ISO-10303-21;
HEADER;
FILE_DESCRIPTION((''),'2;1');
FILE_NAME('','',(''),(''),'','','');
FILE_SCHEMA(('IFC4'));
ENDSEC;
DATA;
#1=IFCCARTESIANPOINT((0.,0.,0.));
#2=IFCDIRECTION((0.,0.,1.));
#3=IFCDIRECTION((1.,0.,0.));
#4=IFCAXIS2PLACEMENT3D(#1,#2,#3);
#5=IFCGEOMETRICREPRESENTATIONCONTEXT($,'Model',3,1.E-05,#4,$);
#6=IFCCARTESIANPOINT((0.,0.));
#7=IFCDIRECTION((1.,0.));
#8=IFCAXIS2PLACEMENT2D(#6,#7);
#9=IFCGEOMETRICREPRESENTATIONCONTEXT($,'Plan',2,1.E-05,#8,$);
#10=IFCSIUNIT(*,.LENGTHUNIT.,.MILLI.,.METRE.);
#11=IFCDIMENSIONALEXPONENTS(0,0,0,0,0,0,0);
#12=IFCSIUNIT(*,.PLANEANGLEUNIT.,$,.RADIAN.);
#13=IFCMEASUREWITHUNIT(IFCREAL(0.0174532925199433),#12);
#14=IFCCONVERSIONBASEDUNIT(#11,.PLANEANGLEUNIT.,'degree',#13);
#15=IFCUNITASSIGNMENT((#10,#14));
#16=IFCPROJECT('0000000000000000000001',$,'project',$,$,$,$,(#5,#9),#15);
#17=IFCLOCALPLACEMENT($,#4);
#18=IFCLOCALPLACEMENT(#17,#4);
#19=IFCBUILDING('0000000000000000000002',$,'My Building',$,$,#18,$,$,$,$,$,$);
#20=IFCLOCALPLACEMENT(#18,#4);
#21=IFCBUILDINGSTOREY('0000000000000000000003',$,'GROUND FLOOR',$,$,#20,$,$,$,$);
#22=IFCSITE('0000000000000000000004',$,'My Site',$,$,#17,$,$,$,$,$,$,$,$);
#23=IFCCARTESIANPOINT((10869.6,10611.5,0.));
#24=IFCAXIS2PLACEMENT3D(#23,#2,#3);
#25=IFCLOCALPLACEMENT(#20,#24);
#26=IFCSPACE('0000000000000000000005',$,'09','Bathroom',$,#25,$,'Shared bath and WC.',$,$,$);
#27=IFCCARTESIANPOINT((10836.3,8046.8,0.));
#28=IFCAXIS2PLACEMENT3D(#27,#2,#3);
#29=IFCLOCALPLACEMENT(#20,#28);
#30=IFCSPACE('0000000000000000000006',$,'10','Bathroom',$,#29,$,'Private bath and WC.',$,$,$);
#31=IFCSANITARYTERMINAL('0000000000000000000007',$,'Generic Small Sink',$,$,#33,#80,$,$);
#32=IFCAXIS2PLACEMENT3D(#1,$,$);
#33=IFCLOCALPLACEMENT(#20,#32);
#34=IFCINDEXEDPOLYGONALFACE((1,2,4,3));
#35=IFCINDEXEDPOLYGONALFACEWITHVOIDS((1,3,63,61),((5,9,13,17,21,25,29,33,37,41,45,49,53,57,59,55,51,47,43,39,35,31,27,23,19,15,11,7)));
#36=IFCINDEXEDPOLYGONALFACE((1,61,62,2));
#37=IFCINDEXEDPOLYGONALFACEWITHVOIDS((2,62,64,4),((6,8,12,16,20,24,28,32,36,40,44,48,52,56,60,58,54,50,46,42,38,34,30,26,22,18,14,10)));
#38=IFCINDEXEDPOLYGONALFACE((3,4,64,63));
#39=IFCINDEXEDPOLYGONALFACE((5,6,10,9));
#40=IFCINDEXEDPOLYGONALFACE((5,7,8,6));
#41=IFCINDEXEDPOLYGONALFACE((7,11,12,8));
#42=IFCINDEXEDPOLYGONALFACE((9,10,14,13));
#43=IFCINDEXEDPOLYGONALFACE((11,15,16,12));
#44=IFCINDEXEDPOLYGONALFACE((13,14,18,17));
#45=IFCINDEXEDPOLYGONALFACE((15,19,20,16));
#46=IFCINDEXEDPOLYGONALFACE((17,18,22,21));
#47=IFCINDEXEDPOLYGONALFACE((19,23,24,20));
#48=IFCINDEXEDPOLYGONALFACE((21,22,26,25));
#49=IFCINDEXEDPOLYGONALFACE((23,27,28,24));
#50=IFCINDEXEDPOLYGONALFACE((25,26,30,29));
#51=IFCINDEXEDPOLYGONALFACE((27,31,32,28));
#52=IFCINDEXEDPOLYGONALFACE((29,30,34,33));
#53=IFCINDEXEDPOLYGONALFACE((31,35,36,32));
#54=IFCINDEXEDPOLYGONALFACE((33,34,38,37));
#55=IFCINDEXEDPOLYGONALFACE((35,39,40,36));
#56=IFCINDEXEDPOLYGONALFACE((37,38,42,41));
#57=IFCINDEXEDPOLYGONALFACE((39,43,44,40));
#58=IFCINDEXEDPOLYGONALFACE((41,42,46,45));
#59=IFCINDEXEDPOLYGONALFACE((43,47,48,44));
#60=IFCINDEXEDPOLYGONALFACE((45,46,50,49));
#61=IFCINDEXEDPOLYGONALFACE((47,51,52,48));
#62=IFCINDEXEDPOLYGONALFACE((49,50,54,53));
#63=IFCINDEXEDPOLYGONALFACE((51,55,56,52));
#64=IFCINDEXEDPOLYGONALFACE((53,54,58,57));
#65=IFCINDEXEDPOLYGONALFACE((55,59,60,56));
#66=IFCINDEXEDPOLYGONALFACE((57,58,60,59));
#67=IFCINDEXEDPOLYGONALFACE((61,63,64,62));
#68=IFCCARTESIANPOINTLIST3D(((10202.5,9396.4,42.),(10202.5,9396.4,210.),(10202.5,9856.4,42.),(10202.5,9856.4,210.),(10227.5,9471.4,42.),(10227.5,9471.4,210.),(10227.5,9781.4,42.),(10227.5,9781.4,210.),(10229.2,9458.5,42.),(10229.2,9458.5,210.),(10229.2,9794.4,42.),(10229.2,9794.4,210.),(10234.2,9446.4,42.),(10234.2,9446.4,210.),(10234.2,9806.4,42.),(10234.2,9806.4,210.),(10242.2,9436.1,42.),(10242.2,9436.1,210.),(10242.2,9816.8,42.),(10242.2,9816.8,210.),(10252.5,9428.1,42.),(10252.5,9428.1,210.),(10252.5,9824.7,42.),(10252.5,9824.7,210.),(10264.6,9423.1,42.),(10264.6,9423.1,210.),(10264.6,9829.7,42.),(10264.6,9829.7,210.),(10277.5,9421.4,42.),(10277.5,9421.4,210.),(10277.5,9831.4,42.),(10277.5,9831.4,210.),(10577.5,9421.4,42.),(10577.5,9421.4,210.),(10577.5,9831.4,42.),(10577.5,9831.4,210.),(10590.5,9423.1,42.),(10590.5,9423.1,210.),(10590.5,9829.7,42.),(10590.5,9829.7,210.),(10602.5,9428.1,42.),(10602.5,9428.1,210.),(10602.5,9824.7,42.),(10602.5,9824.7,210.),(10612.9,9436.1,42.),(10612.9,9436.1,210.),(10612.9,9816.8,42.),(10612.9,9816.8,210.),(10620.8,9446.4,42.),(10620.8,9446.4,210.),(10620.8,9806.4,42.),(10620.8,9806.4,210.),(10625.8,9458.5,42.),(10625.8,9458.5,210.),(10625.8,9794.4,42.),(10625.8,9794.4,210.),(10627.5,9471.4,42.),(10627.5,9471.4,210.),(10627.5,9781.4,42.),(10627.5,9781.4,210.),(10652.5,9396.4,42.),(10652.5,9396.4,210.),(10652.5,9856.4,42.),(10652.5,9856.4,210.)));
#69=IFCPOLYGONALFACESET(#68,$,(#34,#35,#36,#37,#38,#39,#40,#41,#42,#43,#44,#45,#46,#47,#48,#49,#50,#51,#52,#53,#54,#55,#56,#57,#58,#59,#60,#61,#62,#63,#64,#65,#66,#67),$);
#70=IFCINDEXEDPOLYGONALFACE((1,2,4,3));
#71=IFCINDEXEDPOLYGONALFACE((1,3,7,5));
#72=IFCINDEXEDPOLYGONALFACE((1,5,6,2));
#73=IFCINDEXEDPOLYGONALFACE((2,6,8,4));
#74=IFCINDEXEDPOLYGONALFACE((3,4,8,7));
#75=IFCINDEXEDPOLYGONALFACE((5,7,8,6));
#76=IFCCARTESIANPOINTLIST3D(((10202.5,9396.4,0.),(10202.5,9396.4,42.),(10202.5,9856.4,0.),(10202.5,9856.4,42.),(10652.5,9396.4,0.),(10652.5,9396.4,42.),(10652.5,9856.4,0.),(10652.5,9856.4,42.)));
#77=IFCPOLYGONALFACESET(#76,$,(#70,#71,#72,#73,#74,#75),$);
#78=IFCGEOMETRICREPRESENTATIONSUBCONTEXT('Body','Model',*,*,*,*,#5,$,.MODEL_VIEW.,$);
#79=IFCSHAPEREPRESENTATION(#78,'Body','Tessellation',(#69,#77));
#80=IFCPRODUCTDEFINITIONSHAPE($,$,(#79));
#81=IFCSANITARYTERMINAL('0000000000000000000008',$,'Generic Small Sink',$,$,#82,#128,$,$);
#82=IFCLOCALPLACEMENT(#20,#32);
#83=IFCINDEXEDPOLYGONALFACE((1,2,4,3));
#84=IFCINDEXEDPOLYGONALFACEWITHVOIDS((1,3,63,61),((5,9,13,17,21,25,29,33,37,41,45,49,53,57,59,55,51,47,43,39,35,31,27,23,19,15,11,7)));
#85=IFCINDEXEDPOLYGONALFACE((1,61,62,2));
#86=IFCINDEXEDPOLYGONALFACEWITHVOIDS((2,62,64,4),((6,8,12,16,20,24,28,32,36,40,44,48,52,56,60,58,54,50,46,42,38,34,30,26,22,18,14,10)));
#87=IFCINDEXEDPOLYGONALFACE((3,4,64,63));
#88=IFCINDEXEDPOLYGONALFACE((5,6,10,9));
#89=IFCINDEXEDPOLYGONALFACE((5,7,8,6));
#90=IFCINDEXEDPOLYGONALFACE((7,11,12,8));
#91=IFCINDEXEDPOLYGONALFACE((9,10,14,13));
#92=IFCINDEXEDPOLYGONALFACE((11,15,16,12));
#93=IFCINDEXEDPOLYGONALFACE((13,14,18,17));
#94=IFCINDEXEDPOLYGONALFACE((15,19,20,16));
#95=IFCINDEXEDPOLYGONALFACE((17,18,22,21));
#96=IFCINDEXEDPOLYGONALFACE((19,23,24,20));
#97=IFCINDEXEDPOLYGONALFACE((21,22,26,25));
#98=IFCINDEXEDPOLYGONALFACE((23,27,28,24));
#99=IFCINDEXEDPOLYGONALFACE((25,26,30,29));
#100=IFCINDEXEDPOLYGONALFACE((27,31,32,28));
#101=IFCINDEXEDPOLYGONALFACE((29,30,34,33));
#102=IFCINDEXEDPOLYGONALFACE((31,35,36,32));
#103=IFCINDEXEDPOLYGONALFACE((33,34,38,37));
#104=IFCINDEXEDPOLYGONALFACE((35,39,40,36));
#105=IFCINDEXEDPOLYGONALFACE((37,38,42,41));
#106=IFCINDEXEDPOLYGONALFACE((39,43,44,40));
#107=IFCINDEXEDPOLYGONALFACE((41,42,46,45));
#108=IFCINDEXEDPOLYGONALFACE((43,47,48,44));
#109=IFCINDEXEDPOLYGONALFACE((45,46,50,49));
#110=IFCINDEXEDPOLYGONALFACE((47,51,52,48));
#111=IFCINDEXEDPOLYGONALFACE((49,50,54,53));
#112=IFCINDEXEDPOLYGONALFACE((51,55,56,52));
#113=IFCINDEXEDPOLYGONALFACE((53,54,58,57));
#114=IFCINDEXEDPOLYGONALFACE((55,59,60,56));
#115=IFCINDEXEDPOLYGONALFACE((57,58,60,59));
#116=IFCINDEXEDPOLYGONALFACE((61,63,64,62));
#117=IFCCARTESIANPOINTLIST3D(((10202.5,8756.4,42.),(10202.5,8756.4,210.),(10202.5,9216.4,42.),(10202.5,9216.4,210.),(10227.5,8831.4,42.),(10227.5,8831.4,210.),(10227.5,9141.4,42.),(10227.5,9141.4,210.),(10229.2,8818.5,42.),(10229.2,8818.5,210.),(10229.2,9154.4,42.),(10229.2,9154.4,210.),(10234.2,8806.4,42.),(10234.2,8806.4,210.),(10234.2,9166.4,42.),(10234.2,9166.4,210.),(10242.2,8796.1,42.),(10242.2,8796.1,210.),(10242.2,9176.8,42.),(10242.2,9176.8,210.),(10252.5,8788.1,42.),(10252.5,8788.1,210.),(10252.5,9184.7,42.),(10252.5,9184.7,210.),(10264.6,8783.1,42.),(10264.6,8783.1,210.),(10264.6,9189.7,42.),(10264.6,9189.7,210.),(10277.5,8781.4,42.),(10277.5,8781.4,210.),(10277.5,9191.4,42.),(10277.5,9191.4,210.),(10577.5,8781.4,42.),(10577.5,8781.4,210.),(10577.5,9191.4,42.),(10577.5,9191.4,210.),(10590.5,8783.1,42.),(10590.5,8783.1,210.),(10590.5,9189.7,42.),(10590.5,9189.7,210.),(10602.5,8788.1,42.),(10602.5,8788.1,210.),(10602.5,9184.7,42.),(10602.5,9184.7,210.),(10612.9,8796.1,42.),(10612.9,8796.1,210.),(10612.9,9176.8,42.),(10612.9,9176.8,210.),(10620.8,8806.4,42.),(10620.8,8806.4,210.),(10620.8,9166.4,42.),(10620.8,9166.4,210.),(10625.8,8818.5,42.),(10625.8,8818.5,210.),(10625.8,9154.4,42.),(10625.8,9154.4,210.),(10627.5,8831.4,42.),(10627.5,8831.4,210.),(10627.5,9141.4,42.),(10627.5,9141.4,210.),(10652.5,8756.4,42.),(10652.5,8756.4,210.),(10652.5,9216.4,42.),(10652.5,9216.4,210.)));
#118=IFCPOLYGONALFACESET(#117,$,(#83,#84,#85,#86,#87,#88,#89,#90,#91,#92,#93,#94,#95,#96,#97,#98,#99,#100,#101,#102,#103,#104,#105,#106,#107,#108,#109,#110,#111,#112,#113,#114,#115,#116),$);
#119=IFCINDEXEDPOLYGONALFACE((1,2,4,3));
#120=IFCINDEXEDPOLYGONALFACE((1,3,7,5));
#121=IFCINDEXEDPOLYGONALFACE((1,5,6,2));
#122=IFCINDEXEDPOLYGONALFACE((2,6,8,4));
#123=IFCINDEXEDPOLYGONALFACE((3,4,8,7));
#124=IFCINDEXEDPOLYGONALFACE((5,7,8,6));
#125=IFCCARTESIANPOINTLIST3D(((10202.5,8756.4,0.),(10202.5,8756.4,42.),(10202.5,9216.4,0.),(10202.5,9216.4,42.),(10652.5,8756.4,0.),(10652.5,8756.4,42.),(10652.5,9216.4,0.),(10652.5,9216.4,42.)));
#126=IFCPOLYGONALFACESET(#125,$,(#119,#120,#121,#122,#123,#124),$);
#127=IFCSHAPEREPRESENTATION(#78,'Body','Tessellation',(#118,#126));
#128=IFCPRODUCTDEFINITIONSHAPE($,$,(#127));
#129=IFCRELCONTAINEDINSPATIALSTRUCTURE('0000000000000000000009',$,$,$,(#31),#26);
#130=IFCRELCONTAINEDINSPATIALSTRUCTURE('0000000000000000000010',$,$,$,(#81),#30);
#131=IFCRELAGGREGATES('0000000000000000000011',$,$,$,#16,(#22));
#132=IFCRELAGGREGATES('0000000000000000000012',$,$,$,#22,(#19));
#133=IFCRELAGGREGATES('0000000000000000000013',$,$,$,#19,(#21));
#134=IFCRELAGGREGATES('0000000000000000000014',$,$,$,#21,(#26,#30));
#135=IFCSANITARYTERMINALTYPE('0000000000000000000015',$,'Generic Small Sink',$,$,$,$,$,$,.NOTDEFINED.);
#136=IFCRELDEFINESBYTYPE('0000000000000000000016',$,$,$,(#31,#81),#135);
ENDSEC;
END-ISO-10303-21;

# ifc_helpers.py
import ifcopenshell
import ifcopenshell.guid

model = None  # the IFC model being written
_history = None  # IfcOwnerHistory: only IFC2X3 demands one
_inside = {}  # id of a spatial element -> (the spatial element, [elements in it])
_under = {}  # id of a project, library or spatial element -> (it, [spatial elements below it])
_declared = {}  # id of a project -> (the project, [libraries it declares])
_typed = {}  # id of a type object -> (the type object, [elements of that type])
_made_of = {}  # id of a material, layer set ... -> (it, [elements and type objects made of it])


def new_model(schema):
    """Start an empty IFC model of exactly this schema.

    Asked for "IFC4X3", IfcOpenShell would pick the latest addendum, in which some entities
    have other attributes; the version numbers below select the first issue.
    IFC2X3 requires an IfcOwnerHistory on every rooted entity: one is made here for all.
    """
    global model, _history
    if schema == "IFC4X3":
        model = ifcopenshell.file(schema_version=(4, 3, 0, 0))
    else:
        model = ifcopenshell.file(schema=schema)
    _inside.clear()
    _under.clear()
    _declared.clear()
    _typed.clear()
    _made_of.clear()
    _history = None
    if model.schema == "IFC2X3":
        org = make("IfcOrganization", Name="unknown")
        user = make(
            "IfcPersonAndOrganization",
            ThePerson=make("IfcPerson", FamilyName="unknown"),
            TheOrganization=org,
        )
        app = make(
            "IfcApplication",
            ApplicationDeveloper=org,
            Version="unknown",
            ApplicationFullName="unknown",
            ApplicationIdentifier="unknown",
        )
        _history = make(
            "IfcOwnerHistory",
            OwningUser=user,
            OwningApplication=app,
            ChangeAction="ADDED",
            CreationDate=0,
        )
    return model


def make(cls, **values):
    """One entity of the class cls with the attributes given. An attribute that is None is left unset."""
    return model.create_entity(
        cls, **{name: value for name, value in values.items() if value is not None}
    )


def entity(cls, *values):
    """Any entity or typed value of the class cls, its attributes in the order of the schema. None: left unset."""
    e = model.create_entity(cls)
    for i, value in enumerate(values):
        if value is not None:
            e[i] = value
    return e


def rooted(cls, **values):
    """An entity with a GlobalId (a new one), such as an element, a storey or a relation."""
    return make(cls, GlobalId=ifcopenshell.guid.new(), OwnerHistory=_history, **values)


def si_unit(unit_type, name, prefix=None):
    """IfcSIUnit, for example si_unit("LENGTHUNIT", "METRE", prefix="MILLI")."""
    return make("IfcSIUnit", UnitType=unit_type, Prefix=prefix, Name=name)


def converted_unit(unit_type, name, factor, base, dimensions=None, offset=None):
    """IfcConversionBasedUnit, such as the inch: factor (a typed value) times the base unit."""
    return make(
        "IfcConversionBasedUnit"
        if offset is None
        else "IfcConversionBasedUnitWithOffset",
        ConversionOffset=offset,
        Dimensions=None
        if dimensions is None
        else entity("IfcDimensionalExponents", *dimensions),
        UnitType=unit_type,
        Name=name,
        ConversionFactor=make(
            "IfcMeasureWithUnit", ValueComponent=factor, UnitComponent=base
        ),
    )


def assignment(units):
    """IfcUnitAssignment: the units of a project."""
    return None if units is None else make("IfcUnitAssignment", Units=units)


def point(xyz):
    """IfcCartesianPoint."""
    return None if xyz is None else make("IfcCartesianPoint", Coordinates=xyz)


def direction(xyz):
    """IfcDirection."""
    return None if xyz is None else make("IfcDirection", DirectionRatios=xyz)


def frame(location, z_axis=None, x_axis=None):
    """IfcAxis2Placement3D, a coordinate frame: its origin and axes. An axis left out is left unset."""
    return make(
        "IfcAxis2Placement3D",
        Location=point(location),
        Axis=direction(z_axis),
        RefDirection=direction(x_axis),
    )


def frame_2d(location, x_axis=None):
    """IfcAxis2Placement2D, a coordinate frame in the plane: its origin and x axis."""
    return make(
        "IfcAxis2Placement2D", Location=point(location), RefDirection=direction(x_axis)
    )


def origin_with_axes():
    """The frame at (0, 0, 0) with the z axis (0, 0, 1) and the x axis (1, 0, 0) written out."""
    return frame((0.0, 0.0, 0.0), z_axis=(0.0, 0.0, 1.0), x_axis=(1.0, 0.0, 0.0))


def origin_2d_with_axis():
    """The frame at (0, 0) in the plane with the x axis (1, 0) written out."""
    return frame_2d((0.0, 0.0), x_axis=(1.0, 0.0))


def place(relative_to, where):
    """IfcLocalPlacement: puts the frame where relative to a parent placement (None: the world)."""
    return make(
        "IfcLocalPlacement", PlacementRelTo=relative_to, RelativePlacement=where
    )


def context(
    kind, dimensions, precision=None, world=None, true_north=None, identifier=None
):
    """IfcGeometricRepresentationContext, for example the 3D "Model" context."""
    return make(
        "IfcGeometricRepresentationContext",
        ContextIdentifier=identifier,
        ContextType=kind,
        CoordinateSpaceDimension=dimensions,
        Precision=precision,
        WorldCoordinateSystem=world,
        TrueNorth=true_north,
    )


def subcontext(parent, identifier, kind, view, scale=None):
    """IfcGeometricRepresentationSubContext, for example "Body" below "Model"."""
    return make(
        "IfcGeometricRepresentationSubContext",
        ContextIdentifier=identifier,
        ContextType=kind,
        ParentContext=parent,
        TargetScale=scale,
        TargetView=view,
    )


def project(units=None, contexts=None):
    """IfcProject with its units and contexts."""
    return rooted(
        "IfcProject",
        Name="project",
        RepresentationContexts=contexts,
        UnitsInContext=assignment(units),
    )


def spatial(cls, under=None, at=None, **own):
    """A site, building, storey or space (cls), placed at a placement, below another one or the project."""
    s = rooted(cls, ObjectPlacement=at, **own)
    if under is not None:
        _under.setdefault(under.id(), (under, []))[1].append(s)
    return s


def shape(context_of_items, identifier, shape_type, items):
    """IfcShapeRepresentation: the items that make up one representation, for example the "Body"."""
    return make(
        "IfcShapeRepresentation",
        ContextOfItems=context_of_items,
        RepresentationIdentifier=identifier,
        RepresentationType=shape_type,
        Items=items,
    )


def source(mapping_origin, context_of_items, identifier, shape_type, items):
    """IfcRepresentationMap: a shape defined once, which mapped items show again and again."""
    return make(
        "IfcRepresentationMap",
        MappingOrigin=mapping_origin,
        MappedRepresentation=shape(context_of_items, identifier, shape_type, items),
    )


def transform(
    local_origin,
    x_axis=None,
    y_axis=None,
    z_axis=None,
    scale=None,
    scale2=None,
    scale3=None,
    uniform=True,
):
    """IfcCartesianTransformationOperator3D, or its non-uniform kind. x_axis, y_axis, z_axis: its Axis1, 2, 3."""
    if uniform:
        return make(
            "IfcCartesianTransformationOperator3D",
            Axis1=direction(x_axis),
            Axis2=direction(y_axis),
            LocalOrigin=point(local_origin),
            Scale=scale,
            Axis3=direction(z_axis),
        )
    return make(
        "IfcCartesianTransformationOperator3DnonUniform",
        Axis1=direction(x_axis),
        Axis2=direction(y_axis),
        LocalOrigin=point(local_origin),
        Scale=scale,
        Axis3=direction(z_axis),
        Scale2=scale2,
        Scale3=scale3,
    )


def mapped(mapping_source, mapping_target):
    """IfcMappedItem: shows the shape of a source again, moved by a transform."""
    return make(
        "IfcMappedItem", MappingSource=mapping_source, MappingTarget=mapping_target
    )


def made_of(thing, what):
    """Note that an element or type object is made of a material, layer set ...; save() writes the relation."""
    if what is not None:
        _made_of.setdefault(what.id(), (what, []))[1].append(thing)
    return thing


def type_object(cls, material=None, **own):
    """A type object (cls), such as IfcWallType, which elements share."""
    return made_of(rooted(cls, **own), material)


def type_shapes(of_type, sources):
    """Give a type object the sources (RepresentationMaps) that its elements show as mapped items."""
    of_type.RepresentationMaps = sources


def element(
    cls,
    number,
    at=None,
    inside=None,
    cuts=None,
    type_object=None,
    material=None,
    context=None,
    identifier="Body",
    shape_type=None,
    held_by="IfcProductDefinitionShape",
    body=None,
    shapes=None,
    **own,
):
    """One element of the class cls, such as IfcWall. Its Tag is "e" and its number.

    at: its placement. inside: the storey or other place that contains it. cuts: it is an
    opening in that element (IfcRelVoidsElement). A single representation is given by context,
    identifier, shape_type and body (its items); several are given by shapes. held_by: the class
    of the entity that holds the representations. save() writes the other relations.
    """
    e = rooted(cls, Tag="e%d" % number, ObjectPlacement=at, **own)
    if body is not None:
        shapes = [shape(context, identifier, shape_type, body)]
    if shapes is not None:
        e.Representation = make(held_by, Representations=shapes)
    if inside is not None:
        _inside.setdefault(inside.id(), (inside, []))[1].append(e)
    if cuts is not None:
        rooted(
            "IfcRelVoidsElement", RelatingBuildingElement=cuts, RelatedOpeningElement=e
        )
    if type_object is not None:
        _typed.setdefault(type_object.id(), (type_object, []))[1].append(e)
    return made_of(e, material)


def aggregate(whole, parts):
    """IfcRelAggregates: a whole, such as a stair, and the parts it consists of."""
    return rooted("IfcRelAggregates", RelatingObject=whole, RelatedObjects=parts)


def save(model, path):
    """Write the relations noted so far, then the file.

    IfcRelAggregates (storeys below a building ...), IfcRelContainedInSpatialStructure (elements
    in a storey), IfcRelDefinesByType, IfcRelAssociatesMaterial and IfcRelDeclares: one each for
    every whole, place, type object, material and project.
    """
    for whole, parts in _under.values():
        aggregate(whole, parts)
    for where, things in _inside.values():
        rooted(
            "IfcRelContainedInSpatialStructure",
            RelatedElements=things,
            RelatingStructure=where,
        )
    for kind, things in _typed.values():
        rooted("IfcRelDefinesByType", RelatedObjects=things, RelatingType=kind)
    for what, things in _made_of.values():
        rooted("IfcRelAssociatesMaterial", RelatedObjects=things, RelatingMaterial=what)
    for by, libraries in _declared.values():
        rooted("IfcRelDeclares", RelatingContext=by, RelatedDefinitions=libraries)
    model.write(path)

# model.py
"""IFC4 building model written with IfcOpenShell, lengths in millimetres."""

from ifc_helpers import new_model, entity, si_unit, converted_unit, frame, origin_with_axes, origin_2d_with_axis, place, context, subcontext, project, spatial, shape, source, transform, mapped, type_object, type_shapes, element, save


model = new_model("IFC4")

# Units and contexts
model_context = context("Model", 3, precision=1e-05, world=origin_with_axes())
plan_context = context("Plan", 2, precision=1e-05, world=origin_2d_with_axis())
body_context_1 = subcontext(model_context, "Body", "Model", "MODEL_VIEW")
body_context_2 = subcontext(plan_context, "Body", "Plan", "PLAN_VIEW")
ifc_project = project(units=[si_unit("LENGTHUNIT", "METRE", prefix="MILLI"), converted_unit("PLANEANGLEUNIT", "degree", entity("IfcReal", 0.0174532925199433), si_unit("PLANEANGLEUNIT", "RADIAN"), dimensions=[0, 0, 0, 0, 0, 0, 0])], contexts=[model_context, plan_context])

# Site, building, storey
site_placement = place(None, origin_with_axes())
site = spatial("IfcSite", under=ifc_project, at=site_placement, Name="My Site")
building_placement = place(site_placement, origin_with_axes())
building = spatial("IfcBuilding", under=site, at=building_placement, Name="My Building")
storey_placement = place(building_placement, origin_with_axes())
storey = spatial("IfcBuildingStorey", under=building, at=storey_placement, Name="GROUND FLOOR")

# Shared definitions
space_1_placement = place(storey_placement, frame((10869.6, 10611.5, 0.0), z_axis=(0.0, 0.0, 1.0), x_axis=(1.0, 0.0, 0.0)))
space_1 = spatial("IfcSpace", under=storey, at=space_1_placement, Name="09", Description="Bathroom", LongName="Shared bath and WC.")

# Shared definitions
space_2_placement = place(storey_placement, frame((10836.3, 8046.8, 0.0), z_axis=(0.0, 0.0, 1.0), x_axis=(1.0, 0.0, 0.0)))
space_2 = spatial("IfcSpace", under=storey, at=space_2_placement, Name="10", Description="Bathroom", LongName="Private bath and WC.")

# Sanitary terminals
sanitary_terminal_type_1 = type_object("IfcSanitaryTerminalType", Name="Generic Small Sink", PredefinedType="NOTDEFINED")
shared_indexed_poly_curve = entity("IfcIndexedPolyCurve", entity("IfcCartesianPointList2D", [[0.0, 0.0], [450.0, 0.0], [450.0, 460.0], [0.0, 460.0]]), [entity("IfcLineIndex", [1, 2, 3, 4, 1])])
shared_shape_1 = source(origin_with_axes(), body_context_1, "Body", "SweptSolid", [
    entity("IfcExtrudedAreaSolid", entity("IfcArbitraryProfileDefWithVoids", "AREA", None, shared_indexed_poly_curve, [entity("IfcIndexedPolyCurve", entity("IfcCartesianPointList2D", [[25.0, 75.0], [39.6, 39.6], [75.0, 25.0], [375.0, 25.0], [410.4, 39.6], [425.0, 75.0], [425.0, 385.0], [410.4, 420.4], [375.0, 435.0], [75.0, 435.0], [39.6, 420.4], [25.0, 385.0]]), [entity("IfcLineIndex", [12, 1]), entity("IfcArcIndex", [1, 2, 3]), entity("IfcLineIndex", [3, 4]), entity("IfcArcIndex", [4, 5, 6]), entity("IfcLineIndex", [6, 7]), entity("IfcArcIndex", [7, 8, 9]), entity("IfcLineIndex", [9, 10]), entity("IfcArcIndex", [10, 11, 12]), entity("IfcLineIndex", [12, 1])])]), entity("IfcAxis2Placement3D", entity("IfcCartesianPoint", [-225.0, -460.0, 42.0]), entity("IfcDirection", [0.0, 0.0, 1.0]), entity("IfcDirection", [1.0, 0.0, 0.0])), entity("IfcDirection", [0.0, 0.0, 1.0]), 168.0),
    entity("IfcExtrudedAreaSolid", entity("IfcArbitraryClosedProfileDef", "AREA", None, shared_indexed_poly_curve), entity("IfcAxis2Placement3D", entity("IfcCartesianPoint", [-225.0, -460.0, 0.0]), entity("IfcDirection", [0.0, 0.0, 1.0]), entity("IfcDirection", [1.0, 0.0, 0.0])), entity("IfcDirection", [0.0, 0.0, 1.0]), 42.0),
])
shared_shape_2 = source(origin_with_axes(), body_context_2, "Body", "Curve2D", [
    entity("IfcIndexedPolyCurve", entity("IfcCartesianPointList2D", [[-225.0, -460.0], [225.0, -460.0], [225.0, 0.0], [-225.0, 0.0]]), [entity("IfcLineIndex", [1, 2, 3, 4, 1])]),
    entity("IfcIndexedPolyCurve", entity("IfcCartesianPointList2D", [[-200.0, -385.0], [-185.4, -420.4], [-150.0, -435.0], [150.0, -435.0], [185.4, -420.4], [200.0, -385.0], [200.0, -75.0], [185.4, -39.6], [150.0, -25.0], [-150.0, -25.0], [-185.4, -39.6], [-200.0, -75.0]]), [entity("IfcLineIndex", [12, 1]), entity("IfcArcIndex", [1, 2, 3]), entity("IfcLineIndex", [3, 4]), entity("IfcArcIndex", [4, 5, 6]), entity("IfcLineIndex", [6, 7]), entity("IfcArcIndex", [7, 8, 9]), entity("IfcLineIndex", [9, 10]), entity("IfcArcIndex", [10, 11, 12]), entity("IfcLineIndex", [12, 1])]),
    entity("IfcCircle", entity("IfcAxis2Placement2D", entity("IfcCartesianPoint", [0.0, -125.0])), 25.0),
    entity("IfcIndexedPolyCurve", entity("IfcCartesianPointList2D", [[0.0, -12.5], [0.0, -132.5]])),
])
type_shapes(sanitary_terminal_type_1, [shared_shape_1, shared_shape_2])
sanitary_terminal_1_placement = place(space_1_placement, frame((-442.1, -1215.1, 0.0), z_axis=(0.0, 0.0, 1.0), x_axis=(-1.0, 0.0, 0.0)))
element("IfcSanitaryTerminal", 1, at=sanitary_terminal_1_placement, inside=space_1, type_object=sanitary_terminal_type_1, Name="Generic Small Sink", shapes=[
    shape(body_context_1, "Body", "MappedRepresentation", [mapped(shared_shape_1, transform((0.0, 0.0, 0.0), x_axis=(1.0, 0.0, 0.0), y_axis=(0.0, 1.0, 0.0), z_axis=(0.0, 0.0, 1.0), scale=1.0))]),
    shape(body_context_2, "Body", "MappedRepresentation", [mapped(shared_shape_2, transform((0.0, 0.0, 0.0), x_axis=(1.0, 0.0, 0.0), y_axis=(0.0, 1.0, 0.0), z_axis=(0.0, 0.0, 1.0), scale=1.0))]),
])
sanitary_terminal_2_placement = place(space_2_placement, frame((-408.8, 1169.7, 0.0), z_axis=(0.0, 0.0, 1.0), x_axis=(1.0, 0.000001, 0.0)))
element("IfcSanitaryTerminal", 2, at=sanitary_terminal_2_placement, inside=space_2, type_object=sanitary_terminal_type_1, Name="Generic Small Sink", shapes=[
    shape(body_context_1, "Body", "MappedRepresentation", [mapped(shared_shape_1, transform((0.0, 0.0, 0.0), x_axis=(1.0, 0.0, 0.0), y_axis=(0.0, 1.0, 0.0), z_axis=(0.0, 0.0, 1.0), scale=1.0))]),
    shape(body_context_2, "Body", "MappedRepresentation", [mapped(shared_shape_2, transform((0.0, 0.0, 0.0), x_axis=(1.0, 0.0, 0.0), y_axis=(0.0, 1.0, 0.0), z_axis=(0.0, 0.0, 1.0), scale=1.0))]),
])

save(model, "model.ifc")
